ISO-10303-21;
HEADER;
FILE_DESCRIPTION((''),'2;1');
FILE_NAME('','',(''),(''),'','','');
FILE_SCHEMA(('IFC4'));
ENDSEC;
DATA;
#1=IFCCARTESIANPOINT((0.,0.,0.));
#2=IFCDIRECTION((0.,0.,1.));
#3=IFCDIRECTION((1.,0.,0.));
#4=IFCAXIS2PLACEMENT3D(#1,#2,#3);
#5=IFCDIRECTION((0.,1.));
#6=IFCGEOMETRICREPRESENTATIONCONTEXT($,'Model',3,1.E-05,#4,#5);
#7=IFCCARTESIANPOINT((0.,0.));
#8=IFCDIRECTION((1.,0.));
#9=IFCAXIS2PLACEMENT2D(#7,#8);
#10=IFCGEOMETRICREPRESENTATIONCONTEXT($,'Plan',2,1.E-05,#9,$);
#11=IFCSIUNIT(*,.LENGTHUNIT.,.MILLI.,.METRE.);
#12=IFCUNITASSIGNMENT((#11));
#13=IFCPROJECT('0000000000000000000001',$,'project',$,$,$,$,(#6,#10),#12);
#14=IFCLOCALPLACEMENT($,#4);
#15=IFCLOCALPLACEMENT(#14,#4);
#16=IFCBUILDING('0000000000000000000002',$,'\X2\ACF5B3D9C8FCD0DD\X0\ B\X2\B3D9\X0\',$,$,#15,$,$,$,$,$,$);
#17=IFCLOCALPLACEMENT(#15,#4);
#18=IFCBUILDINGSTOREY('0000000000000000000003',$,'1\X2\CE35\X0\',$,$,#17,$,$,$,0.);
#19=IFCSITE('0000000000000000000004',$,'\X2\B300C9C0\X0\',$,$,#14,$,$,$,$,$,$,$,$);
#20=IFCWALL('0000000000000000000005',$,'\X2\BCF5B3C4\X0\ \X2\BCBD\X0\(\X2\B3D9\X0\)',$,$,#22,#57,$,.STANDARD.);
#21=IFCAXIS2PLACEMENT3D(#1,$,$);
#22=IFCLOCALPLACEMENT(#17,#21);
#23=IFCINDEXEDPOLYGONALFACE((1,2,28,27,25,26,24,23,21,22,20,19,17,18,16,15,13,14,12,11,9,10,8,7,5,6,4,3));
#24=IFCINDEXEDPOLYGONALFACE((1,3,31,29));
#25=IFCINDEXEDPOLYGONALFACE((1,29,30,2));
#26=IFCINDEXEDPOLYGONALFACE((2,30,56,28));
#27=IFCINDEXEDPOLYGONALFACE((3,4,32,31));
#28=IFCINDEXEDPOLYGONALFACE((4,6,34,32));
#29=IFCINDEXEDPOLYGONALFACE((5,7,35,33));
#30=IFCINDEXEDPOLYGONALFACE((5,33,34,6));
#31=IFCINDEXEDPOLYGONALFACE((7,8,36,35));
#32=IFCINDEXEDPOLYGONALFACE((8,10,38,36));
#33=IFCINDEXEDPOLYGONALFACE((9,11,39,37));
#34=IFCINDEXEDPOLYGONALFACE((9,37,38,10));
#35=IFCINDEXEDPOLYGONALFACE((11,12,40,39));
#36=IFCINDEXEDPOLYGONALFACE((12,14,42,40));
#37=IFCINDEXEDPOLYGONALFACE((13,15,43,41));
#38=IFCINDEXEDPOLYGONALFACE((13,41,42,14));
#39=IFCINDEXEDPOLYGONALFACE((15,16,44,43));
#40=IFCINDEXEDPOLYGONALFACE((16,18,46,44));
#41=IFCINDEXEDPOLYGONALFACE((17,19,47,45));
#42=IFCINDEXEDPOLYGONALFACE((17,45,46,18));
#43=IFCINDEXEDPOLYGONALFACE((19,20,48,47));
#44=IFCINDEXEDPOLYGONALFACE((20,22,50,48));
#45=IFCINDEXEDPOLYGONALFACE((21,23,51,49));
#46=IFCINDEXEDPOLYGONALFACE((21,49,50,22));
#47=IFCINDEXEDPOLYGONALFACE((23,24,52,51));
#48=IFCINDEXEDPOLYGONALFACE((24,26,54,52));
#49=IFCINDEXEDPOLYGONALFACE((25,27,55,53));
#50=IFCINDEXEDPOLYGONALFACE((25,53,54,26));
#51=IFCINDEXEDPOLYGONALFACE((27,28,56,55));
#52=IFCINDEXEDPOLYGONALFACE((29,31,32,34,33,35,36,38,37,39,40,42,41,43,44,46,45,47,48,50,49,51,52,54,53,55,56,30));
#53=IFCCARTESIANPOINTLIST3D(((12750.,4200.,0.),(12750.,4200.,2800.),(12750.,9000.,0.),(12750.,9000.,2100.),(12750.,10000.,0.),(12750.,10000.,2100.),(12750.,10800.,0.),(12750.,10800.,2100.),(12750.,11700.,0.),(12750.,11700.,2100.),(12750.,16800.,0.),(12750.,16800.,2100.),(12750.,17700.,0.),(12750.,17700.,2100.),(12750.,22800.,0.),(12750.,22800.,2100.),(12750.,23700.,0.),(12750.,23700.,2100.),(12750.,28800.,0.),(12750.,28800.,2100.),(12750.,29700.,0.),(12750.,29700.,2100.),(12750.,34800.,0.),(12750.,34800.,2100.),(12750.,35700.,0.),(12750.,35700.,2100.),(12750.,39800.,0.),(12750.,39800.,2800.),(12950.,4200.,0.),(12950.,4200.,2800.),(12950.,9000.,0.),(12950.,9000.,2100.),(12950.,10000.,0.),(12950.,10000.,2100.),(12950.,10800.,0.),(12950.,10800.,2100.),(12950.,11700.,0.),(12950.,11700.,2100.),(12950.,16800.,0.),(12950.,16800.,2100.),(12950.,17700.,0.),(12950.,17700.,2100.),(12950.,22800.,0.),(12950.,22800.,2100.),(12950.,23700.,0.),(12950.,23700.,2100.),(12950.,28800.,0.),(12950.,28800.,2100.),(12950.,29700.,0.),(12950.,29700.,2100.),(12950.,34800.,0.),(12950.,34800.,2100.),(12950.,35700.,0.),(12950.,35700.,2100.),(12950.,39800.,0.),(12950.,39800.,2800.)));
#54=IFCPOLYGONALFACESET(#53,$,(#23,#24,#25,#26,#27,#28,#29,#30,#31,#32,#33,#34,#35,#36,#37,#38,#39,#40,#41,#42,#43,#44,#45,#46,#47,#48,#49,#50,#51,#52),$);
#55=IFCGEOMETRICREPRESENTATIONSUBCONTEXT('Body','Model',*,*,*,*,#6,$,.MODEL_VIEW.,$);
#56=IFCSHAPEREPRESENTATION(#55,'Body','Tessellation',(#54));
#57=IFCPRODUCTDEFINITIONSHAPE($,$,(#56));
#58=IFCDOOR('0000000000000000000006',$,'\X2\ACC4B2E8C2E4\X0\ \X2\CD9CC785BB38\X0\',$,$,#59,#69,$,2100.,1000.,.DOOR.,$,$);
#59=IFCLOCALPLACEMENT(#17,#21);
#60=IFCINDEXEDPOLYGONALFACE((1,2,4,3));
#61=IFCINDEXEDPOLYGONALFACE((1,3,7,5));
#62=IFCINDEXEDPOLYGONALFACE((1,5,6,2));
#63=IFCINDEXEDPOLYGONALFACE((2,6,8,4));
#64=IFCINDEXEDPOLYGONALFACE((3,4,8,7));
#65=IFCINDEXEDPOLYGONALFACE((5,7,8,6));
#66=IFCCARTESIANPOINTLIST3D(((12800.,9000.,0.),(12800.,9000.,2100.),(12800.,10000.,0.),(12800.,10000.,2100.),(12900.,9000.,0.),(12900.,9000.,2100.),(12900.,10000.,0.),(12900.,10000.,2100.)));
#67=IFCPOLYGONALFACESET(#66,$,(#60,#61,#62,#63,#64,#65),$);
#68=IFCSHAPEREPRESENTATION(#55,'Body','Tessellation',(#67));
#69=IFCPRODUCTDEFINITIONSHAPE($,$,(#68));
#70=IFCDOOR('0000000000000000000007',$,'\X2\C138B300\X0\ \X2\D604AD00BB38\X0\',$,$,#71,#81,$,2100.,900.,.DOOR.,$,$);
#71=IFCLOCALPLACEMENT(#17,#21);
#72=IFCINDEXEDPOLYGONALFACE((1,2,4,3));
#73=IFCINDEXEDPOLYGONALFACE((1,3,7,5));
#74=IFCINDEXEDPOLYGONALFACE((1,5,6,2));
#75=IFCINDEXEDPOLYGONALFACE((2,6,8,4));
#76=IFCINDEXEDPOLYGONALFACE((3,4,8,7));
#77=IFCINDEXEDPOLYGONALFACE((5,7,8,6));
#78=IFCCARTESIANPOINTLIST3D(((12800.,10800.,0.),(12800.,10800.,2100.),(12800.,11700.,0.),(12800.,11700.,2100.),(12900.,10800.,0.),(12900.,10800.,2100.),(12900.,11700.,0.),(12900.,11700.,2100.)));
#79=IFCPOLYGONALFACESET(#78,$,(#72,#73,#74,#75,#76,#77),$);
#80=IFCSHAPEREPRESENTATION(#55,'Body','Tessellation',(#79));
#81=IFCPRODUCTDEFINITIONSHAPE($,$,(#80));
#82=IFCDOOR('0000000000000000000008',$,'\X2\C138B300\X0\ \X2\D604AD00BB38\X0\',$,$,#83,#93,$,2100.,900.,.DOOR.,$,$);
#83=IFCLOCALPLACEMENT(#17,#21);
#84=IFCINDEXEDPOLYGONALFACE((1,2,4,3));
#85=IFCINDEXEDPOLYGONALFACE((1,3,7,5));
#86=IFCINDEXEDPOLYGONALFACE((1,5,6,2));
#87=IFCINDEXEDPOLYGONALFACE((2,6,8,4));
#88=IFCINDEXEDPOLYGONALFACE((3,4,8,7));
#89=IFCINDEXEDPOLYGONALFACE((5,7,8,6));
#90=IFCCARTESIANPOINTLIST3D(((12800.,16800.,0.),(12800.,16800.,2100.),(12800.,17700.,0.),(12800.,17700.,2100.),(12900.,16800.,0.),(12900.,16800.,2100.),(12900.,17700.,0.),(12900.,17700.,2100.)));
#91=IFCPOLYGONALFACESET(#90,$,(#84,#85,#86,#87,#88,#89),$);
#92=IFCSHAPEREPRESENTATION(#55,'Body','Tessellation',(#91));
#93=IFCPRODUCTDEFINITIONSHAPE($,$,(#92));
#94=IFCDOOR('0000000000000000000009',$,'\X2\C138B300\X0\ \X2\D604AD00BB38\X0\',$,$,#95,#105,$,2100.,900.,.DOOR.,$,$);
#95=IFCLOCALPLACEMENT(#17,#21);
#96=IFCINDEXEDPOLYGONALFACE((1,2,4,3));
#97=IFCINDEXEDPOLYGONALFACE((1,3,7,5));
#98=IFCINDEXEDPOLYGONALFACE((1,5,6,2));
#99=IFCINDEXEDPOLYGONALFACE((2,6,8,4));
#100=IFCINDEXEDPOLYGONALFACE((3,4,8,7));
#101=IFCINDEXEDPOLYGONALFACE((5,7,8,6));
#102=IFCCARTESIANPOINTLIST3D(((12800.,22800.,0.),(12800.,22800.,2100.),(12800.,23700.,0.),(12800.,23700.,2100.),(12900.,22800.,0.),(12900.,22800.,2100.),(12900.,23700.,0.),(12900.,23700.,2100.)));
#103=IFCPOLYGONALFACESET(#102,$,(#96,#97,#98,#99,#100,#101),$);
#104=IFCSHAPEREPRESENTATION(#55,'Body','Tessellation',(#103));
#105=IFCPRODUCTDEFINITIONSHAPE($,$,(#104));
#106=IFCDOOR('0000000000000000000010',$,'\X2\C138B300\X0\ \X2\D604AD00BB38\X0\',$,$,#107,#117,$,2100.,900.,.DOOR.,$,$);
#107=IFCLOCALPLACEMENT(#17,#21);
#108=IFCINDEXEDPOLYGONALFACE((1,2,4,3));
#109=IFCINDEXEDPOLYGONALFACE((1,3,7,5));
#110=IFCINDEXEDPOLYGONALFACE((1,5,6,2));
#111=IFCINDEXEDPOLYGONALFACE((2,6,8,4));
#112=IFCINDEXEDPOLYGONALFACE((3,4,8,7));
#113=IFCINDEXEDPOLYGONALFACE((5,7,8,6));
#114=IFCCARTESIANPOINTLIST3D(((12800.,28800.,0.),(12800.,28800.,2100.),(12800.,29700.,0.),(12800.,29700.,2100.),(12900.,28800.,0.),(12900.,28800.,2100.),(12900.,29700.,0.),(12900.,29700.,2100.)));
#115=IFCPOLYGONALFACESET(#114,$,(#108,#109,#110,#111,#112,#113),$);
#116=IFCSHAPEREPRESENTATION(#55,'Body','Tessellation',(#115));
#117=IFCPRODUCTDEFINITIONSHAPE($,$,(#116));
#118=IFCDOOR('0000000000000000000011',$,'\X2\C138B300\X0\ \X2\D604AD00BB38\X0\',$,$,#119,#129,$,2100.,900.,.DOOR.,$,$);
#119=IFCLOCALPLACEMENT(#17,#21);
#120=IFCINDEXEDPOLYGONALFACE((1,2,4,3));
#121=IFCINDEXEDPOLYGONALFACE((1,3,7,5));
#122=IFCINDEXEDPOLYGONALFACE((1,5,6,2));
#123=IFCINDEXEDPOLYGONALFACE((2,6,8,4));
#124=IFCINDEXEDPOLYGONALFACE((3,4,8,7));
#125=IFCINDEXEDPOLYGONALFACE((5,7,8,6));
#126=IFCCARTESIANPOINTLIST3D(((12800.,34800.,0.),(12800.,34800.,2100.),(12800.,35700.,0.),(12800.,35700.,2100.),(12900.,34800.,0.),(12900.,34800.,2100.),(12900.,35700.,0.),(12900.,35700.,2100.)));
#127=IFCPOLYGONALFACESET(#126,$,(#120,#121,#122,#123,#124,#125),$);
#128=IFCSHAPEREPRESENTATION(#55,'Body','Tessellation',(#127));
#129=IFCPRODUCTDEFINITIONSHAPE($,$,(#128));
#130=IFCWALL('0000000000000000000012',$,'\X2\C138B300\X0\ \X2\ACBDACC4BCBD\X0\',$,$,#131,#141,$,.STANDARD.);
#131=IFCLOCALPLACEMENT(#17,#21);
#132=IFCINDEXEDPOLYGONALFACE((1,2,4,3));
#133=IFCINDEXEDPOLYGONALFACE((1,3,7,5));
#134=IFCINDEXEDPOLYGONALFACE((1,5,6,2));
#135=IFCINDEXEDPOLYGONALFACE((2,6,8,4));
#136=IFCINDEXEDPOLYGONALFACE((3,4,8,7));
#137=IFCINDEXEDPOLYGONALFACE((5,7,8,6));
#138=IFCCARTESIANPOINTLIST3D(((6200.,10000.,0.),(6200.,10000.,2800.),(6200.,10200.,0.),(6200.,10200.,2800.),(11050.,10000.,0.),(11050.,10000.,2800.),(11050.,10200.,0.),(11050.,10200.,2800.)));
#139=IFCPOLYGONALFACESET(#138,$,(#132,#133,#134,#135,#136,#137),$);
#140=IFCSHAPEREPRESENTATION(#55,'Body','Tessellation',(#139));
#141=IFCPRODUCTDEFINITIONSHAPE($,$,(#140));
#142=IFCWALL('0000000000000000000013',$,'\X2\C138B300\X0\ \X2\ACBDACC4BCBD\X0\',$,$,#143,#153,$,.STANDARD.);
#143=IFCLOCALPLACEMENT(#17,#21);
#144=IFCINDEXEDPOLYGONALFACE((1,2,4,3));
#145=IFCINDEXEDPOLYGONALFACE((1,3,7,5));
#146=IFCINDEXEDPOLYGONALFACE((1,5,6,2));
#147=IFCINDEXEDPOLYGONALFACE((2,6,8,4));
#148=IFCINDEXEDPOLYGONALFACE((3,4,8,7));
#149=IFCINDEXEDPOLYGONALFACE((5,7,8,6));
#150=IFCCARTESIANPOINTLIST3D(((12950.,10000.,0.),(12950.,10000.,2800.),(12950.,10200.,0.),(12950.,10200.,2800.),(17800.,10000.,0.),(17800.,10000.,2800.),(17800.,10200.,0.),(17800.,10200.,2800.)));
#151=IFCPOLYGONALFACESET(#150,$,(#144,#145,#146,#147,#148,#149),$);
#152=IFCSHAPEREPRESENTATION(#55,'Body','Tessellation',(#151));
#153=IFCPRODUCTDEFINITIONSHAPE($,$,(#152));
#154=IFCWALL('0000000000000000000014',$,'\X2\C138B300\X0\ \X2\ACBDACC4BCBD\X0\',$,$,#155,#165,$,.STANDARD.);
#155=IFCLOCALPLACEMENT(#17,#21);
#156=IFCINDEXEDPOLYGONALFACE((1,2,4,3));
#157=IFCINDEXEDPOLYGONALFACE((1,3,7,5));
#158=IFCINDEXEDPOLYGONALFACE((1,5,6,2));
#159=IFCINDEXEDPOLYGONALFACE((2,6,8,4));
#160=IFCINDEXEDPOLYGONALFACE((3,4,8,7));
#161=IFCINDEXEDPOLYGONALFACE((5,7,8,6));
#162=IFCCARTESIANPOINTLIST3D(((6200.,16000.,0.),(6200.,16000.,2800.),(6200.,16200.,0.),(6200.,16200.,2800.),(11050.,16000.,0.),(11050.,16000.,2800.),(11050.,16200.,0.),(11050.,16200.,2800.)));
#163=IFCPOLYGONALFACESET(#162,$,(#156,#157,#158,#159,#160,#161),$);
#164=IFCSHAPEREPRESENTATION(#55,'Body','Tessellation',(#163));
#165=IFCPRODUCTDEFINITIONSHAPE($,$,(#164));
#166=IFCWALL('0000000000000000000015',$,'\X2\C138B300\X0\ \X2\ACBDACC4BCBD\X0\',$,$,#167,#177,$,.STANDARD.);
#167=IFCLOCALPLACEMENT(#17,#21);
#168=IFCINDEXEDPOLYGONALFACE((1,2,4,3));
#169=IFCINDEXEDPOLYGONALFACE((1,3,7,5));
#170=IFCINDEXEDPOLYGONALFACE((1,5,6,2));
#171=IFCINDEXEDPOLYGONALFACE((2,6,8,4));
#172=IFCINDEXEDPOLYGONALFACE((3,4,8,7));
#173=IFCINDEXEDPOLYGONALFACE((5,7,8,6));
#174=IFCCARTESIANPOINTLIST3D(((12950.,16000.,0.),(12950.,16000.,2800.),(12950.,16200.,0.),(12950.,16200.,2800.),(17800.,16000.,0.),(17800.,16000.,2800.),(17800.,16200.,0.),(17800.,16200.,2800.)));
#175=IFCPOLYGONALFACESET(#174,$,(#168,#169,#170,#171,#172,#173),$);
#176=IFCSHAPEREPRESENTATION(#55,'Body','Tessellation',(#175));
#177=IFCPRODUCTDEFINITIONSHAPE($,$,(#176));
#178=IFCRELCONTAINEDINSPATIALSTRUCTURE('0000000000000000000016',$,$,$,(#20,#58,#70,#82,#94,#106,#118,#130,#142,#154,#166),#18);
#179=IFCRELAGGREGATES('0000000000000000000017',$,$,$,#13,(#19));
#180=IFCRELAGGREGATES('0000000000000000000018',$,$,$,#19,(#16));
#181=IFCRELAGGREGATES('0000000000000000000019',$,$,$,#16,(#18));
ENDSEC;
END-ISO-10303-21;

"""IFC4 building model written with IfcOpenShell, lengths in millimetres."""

from ifc_helpers import new_model, si_unit, direction, origin_with_axes, origin_2d_with_axis, place, context, subcontext, project, spatial, polyline, outline, extrude, element, fill, save


model = new_model("IFC4")

# Units and contexts
model_context = context("Model", 3, precision=1e-05, world=origin_with_axes(), true_north=direction((0.0, 1.0)))
plan_context = context("Plan", 2, precision=1e-05, world=origin_2d_with_axis())
body_context = subcontext(model_context, "Body", "Model", "MODEL_VIEW")
ifc_project = project(units=[si_unit("LENGTHUNIT", "METRE", prefix="MILLI")], contexts=[model_context, plan_context])

# Site, building, storey
site_placement = place(None, origin_with_axes())
site = spatial("IfcSite", under=ifc_project, at=site_placement, Name="대지")
building_placement = place(site_placement, origin_with_axes())
building = spatial("IfcBuilding", under=site, at=building_placement, Name="공동주택 B동")
storey_placement = place(building_placement, origin_with_axes())
storey = spatial("IfcBuildingStorey", under=building, at=storey_placement, Name="1층", Elevation=0.0)

# Wall, openings, doors
wall_1_placement = place(storey_placement, origin_with_axes())
wall_1 = element("IfcWall", 1, at=wall_1_placement, inside=storey, Name="복도 벽(동)", PredefinedType="STANDARD", context=body_context, shape_type="SweptSolid", body=[
    extrude(outline(polyline([(12750.0, 4200.0), (12750.0, 39800.0), (12950.0, 39800.0), (12950.0, 4200.0), (12750.0, 4200.0)])), origin_with_axes(), (0.0, 0.0, 1.0), 2800.0),
])
opening_1_placement = place(storey_placement, origin_with_axes())
opening_1 = element("IfcOpeningElement", 2, at=opening_1_placement, cuts=wall_1, PredefinedType="OPENING", context=body_context, shape_type="SweptSolid", body=[
    extrude(outline(polyline([(13000.0, 9000.0), (13000.0, 10000.0), (12700.0, 10000.0), (12700.0, 9000.0), (13000.0, 9000.0)])), origin_with_axes(), (0.0, 0.0, 1.0), 2100.0),
])
opening_2_placement = place(storey_placement, origin_with_axes())
opening_2 = element("IfcOpeningElement", 3, at=opening_2_placement, cuts=wall_1, PredefinedType="OPENING", context=body_context, shape_type="SweptSolid", body=[
    extrude(outline(polyline([(13000.0, 10800.0), (13000.0, 11700.0), (12700.0, 11700.0), (12700.0, 10800.0), (13000.0, 10800.0)])), origin_with_axes(), (0.0, 0.0, 1.0), 2100.0),
])
opening_3_placement = place(storey_placement, origin_with_axes())
opening_3 = element("IfcOpeningElement", 4, at=opening_3_placement, cuts=wall_1, PredefinedType="OPENING", context=body_context, shape_type="SweptSolid", body=[
    extrude(outline(polyline([(13000.0, 16800.0), (13000.0, 17700.0), (12700.0, 17700.0), (12700.0, 16800.0), (13000.0, 16800.0)])), origin_with_axes(), (0.0, 0.0, 1.0), 2100.0),
])
opening_4_placement = place(storey_placement, origin_with_axes())
opening_4 = element("IfcOpeningElement", 5, at=opening_4_placement, cuts=wall_1, PredefinedType="OPENING", context=body_context, shape_type="SweptSolid", body=[
    extrude(outline(polyline([(13000.0, 22800.0), (13000.0, 23700.0), (12700.0, 23700.0), (12700.0, 22800.0), (13000.0, 22800.0)])), origin_with_axes(), (0.0, 0.0, 1.0), 2100.0),
])
opening_5_placement = place(storey_placement, origin_with_axes())
opening_5 = element("IfcOpeningElement", 6, at=opening_5_placement, cuts=wall_1, PredefinedType="OPENING", context=body_context, shape_type="SweptSolid", body=[
    extrude(outline(polyline([(13000.0, 28800.0), (13000.0, 29700.0), (12700.0, 29700.0), (12700.0, 28800.0), (13000.0, 28800.0)])), origin_with_axes(), (0.0, 0.0, 1.0), 2100.0),
])
opening_6_placement = place(storey_placement, origin_with_axes())
opening_6 = element("IfcOpeningElement", 7, at=opening_6_placement, cuts=wall_1, PredefinedType="OPENING", context=body_context, shape_type="SweptSolid", body=[
    extrude(outline(polyline([(13000.0, 34800.0), (13000.0, 35700.0), (12700.0, 35700.0), (12700.0, 34800.0), (13000.0, 34800.0)])), origin_with_axes(), (0.0, 0.0, 1.0), 2100.0),
])
door_1_placement = place(storey_placement, origin_with_axes())
door_1 = element("IfcDoor", 8, at=door_1_placement, inside=storey, Name="계단실 출입문", OverallHeight=2100.0, OverallWidth=1000.0, PredefinedType="DOOR", context=body_context, shape_type="SweptSolid", body=[
    extrude(outline(polyline([(12900.0, 9000.0), (12900.0, 10000.0), (12800.0, 10000.0), (12800.0, 9000.0), (12900.0, 9000.0)])), origin_with_axes(), (0.0, 0.0, 1.0), 2100.0),
])
fill(opening_1, door_1)
door_2_placement = place(storey_placement, origin_with_axes())
door_2 = element("IfcDoor", 9, at=door_2_placement, inside=storey, Name="세대 현관문", OverallHeight=2100.0, OverallWidth=900.0, PredefinedType="DOOR", context=body_context, shape_type="SweptSolid", body=[
    extrude(outline(polyline([(12900.0, 10800.0), (12900.0, 11700.0), (12800.0, 11700.0), (12800.0, 10800.0), (12900.0, 10800.0)])), origin_with_axes(), (0.0, 0.0, 1.0), 2100.0),
])
fill(opening_2, door_2)
door_3_placement = place(storey_placement, origin_with_axes())
door_3 = element("IfcDoor", 10, at=door_3_placement, inside=storey, Name="세대 현관문", OverallHeight=2100.0, OverallWidth=900.0, PredefinedType="DOOR", context=body_context, shape_type="SweptSolid", body=[
    extrude(outline(polyline([(12900.0, 16800.0), (12900.0, 17700.0), (12800.0, 17700.0), (12800.0, 16800.0), (12900.0, 16800.0)])), origin_with_axes(), (0.0, 0.0, 1.0), 2100.0),
])
fill(opening_3, door_3)
door_4_placement = place(storey_placement, origin_with_axes())
door_4 = element("IfcDoor", 11, at=door_4_placement, inside=storey, Name="세대 현관문", OverallHeight=2100.0, OverallWidth=900.0, PredefinedType="DOOR", context=body_context, shape_type="SweptSolid", body=[
    extrude(outline(polyline([(12900.0, 22800.0), (12900.0, 23700.0), (12800.0, 23700.0), (12800.0, 22800.0), (12900.0, 22800.0)])), origin_with_axes(), (0.0, 0.0, 1.0), 2100.0),
])
fill(opening_4, door_4)
door_5_placement = place(storey_placement, origin_with_axes())
door_5 = element("IfcDoor", 12, at=door_5_placement, inside=storey, Name="세대 현관문", OverallHeight=2100.0, OverallWidth=900.0, PredefinedType="DOOR", context=body_context, shape_type="SweptSolid", body=[
    extrude(outline(polyline([(12900.0, 28800.0), (12900.0, 29700.0), (12800.0, 29700.0), (12800.0, 28800.0), (12900.0, 28800.0)])), origin_with_axes(), (0.0, 0.0, 1.0), 2100.0),
])
fill(opening_5, door_5)
door_6_placement = place(storey_placement, origin_with_axes())
door_6 = element("IfcDoor", 13, at=door_6_placement, inside=storey, Name="세대 현관문", OverallHeight=2100.0, OverallWidth=900.0, PredefinedType="DOOR", context=body_context, shape_type="SweptSolid", body=[
    extrude(outline(polyline([(12900.0, 34800.0), (12900.0, 35700.0), (12800.0, 35700.0), (12800.0, 34800.0), (12900.0, 34800.0)])), origin_with_axes(), (0.0, 0.0, 1.0), 2100.0),
])
fill(opening_6, door_6)

# Walls
wall_2_placement = place(storey_placement, origin_with_axes())
element("IfcWall", 14, at=wall_2_placement, inside=storey, Name="세대 경계벽", PredefinedType="STANDARD", context=body_context, shape_type="SweptSolid", body=[
    extrude(outline(polyline([(6200.0, 10200.0), (11050.0, 10200.0), (11050.0, 10000.0), (6200.0, 10000.0), (6200.0, 10200.0)])), origin_with_axes(), (0.0, 0.0, 1.0), 2800.0),
])
wall_3_placement = place(storey_placement, origin_with_axes())
element("IfcWall", 15, at=wall_3_placement, inside=storey, Name="세대 경계벽", PredefinedType="STANDARD", context=body_context, shape_type="SweptSolid", body=[
    extrude(outline(polyline([(12950.0, 10200.0), (17800.0, 10200.0), (17800.0, 10000.0), (12950.0, 10000.0), (12950.0, 10200.0)])), origin_with_axes(), (0.0, 0.0, 1.0), 2800.0),
])
wall_4_placement = place(storey_placement, origin_with_axes())
element("IfcWall", 16, at=wall_4_placement, inside=storey, Name="세대 경계벽", PredefinedType="STANDARD", context=body_context, shape_type="SweptSolid", body=[
    extrude(outline(polyline([(6200.0, 16200.0), (11050.0, 16200.0), (11050.0, 16000.0), (6200.0, 16000.0), (6200.0, 16200.0)])), origin_with_axes(), (0.0, 0.0, 1.0), 2800.0),
])
wall_5_placement = place(storey_placement, origin_with_axes())
element("IfcWall", 17, at=wall_5_placement, inside=storey, Name="세대 경계벽", PredefinedType="STANDARD", context=body_context, shape_type="SweptSolid", body=[
    extrude(outline(polyline([(12950.0, 16200.0), (17800.0, 16200.0), (17800.0, 16000.0), (12950.0, 16000.0), (12950.0, 16200.0)])), origin_with_axes(), (0.0, 0.0, 1.0), 2800.0),
])

save(model, "model.ifc")
